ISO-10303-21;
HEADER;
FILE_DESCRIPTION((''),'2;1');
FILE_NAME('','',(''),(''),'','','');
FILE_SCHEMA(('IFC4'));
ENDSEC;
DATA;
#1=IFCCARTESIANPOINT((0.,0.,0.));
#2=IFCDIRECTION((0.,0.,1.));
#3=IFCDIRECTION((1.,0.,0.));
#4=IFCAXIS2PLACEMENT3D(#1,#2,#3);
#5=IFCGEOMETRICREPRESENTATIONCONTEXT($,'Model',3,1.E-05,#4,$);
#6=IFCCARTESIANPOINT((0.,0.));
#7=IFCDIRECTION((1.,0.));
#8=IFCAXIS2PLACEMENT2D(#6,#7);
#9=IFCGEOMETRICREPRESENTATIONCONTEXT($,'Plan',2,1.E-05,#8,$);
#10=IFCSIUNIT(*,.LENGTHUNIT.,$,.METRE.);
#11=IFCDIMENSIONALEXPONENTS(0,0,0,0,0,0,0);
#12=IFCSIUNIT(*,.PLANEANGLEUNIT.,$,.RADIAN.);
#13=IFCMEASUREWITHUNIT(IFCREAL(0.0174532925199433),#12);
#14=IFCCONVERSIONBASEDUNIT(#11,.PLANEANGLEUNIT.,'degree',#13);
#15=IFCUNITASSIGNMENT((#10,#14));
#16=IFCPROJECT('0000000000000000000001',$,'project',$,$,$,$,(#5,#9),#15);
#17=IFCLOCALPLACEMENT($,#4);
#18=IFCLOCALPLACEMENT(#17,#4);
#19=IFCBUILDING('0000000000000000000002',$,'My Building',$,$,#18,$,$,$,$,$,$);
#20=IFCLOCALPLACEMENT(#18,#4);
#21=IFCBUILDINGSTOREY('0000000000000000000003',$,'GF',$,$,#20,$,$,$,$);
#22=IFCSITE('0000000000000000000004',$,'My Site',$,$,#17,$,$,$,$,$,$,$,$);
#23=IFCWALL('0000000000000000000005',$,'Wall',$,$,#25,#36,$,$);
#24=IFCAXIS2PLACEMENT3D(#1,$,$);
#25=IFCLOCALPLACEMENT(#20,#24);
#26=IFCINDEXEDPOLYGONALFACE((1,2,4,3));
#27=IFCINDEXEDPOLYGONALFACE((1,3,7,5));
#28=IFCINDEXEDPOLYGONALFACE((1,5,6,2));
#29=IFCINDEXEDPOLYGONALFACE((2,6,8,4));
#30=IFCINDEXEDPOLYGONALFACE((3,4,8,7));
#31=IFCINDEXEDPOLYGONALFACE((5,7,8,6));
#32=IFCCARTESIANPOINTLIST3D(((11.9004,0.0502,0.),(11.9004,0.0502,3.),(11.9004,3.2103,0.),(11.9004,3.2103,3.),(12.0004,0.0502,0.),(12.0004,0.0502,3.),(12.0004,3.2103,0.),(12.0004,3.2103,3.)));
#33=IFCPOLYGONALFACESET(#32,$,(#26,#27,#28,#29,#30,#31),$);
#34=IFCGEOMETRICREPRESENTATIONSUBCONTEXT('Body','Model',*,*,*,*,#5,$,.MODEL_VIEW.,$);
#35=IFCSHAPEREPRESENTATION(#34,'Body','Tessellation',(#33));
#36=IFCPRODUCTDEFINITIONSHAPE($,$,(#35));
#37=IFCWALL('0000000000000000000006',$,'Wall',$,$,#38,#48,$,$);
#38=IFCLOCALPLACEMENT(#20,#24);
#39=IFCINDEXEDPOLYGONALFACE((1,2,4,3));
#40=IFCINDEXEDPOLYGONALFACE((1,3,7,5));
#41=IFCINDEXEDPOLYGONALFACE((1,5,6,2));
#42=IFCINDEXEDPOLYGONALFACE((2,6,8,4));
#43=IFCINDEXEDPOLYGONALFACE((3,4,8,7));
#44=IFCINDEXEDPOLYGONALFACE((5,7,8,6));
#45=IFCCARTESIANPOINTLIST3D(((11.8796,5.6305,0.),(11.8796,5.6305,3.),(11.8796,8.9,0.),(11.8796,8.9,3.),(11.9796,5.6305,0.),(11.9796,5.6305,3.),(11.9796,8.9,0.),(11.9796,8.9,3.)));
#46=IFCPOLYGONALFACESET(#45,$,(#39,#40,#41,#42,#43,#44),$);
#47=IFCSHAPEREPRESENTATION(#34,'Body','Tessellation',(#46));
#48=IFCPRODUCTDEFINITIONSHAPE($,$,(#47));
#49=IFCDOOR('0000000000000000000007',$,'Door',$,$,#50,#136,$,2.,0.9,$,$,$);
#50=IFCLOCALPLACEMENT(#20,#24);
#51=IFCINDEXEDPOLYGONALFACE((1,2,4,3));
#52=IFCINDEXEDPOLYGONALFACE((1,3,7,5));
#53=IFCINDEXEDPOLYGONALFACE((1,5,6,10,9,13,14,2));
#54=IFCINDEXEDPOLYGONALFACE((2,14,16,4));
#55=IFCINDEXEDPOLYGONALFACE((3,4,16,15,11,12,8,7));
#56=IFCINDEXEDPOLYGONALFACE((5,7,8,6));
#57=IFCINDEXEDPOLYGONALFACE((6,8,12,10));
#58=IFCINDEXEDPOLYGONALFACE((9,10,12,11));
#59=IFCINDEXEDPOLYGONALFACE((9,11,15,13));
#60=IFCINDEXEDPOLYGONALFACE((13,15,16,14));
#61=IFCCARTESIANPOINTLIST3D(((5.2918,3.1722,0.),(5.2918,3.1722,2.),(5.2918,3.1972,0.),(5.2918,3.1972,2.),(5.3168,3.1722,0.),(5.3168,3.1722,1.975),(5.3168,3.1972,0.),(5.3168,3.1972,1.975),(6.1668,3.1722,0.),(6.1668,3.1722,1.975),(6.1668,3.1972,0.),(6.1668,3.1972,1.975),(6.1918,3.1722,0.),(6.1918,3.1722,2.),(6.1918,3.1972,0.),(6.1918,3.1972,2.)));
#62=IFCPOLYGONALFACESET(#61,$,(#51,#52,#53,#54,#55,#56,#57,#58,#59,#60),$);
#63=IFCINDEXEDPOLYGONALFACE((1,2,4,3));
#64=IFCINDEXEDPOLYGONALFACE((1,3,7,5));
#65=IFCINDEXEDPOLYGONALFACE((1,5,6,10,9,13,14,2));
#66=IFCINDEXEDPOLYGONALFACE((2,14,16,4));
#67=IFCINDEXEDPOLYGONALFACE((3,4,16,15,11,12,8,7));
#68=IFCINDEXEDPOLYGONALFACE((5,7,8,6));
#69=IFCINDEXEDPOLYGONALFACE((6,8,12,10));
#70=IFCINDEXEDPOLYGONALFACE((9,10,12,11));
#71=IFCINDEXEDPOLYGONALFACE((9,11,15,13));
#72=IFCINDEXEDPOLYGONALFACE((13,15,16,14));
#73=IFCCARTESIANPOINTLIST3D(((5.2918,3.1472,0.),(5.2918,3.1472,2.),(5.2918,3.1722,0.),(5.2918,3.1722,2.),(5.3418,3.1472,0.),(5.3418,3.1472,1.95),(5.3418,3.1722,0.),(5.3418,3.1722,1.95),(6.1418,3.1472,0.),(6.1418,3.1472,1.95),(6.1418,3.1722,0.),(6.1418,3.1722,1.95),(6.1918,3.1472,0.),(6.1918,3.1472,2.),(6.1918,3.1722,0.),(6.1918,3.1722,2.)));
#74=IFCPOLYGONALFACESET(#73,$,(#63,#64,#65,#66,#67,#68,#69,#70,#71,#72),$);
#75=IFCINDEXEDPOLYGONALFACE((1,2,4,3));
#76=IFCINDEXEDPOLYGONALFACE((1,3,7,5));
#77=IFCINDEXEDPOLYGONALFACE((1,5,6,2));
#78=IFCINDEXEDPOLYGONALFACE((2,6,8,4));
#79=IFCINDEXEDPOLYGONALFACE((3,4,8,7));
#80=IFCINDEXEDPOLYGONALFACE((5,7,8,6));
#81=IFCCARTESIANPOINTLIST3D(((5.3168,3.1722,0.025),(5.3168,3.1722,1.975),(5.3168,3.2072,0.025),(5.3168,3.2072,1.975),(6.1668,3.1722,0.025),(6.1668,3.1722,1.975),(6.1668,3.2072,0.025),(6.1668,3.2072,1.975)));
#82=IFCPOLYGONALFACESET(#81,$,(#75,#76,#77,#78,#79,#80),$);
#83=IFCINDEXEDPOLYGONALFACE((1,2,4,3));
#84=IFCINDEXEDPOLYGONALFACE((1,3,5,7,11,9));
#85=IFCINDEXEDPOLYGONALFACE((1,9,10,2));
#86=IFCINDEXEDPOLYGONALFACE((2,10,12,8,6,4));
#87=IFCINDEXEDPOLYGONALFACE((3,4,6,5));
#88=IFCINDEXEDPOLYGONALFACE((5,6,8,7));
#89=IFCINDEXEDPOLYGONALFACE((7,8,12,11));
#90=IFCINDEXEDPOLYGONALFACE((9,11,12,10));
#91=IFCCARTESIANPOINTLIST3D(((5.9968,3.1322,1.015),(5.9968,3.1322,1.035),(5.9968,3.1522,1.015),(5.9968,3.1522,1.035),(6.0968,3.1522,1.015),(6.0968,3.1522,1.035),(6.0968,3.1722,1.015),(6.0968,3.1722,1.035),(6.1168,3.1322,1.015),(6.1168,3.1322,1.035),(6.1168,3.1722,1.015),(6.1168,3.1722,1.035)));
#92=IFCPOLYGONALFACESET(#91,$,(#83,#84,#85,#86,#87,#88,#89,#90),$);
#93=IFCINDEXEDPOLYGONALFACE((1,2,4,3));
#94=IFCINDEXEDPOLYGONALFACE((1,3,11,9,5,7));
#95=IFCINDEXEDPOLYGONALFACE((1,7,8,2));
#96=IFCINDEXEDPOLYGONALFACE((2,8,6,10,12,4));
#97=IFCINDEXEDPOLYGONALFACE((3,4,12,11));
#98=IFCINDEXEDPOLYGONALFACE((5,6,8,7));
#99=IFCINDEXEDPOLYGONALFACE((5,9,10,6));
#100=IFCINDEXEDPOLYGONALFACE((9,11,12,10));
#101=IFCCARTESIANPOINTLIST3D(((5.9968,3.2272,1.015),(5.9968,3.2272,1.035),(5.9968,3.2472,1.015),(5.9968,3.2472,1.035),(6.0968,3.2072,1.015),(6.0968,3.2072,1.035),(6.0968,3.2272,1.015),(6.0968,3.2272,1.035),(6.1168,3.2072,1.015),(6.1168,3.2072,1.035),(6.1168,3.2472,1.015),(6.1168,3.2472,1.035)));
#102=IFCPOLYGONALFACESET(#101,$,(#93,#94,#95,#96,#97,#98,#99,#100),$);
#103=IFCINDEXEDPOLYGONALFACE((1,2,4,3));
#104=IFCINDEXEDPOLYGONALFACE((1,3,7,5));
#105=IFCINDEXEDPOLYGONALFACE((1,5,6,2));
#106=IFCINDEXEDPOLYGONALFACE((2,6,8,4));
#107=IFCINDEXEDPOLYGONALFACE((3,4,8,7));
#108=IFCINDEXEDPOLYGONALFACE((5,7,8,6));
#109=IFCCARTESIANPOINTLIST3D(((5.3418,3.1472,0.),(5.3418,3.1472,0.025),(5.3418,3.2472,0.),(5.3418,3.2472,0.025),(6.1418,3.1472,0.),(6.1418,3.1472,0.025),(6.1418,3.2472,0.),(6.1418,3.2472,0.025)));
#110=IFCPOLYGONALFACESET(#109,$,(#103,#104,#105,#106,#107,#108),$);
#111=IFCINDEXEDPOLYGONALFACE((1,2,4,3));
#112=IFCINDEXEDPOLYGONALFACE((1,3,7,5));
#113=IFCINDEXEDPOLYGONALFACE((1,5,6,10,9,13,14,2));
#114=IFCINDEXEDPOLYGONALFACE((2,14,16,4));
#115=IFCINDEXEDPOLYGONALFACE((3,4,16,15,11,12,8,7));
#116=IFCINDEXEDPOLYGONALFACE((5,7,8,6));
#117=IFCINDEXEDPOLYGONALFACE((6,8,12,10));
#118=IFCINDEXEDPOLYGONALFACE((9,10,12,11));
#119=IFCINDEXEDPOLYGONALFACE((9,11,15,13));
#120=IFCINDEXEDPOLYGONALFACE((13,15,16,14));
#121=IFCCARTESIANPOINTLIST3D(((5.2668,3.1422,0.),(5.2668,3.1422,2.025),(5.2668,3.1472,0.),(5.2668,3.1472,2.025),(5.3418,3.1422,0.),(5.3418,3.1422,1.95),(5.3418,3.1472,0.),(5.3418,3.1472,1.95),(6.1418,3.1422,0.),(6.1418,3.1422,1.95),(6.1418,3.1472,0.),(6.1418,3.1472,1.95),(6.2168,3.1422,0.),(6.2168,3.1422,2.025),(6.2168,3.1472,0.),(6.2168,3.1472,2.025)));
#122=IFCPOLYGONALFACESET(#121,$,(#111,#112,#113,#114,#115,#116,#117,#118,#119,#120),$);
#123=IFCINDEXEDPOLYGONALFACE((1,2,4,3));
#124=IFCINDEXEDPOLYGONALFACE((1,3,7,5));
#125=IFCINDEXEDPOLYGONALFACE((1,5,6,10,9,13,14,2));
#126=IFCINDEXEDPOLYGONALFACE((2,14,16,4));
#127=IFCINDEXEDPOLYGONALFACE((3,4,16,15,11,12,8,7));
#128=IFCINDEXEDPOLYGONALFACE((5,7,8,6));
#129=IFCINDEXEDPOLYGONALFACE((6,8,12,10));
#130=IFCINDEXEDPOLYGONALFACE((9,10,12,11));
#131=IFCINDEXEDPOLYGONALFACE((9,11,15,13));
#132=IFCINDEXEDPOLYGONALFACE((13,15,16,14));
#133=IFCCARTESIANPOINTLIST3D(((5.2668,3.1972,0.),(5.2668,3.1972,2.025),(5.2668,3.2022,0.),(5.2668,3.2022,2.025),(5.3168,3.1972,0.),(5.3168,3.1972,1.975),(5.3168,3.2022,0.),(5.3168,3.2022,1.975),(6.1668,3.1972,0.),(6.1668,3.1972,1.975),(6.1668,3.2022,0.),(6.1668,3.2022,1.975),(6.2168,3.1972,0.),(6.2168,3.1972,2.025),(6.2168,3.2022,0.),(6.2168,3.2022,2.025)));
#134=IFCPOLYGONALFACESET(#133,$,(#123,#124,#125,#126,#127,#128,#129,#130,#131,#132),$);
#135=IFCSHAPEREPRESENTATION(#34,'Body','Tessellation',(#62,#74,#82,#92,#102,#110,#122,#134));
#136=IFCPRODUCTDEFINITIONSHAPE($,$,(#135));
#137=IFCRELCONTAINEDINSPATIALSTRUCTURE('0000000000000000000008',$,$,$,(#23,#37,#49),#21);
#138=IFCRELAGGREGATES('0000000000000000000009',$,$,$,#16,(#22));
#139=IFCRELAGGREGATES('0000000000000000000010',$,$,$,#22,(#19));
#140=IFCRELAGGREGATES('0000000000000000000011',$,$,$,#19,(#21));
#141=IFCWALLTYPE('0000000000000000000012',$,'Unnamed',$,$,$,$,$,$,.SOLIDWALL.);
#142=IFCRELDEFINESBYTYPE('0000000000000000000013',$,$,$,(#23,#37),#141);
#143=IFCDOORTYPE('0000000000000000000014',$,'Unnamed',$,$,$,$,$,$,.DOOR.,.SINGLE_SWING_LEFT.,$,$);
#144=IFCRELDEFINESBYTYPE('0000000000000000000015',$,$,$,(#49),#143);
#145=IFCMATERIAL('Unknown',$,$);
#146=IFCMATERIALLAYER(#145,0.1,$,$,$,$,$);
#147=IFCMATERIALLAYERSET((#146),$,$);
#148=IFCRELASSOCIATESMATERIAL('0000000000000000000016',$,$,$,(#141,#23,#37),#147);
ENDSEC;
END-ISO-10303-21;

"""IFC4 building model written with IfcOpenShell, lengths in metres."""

from ifc_helpers import new_model, entity, si_unit, converted_unit, frame, origin_with_axes, origin_2d_with_axis, place, context, subcontext, project, spatial, line, indexed_curve, outline, extrude, shape, source, transform, mapped, material, layer, layer_set, layer_usage, type_object, type_shapes, element, save


model = new_model("IFC4")

# Units and contexts
model_context = context("Model", 3, precision=1e-05, world=origin_with_axes())
plan_context = context("Plan", 2, precision=1e-05, world=origin_2d_with_axis())
body_context_1 = subcontext(model_context, "Body", "Model", "MODEL_VIEW")
body_context_2 = subcontext(plan_context, "Body", "Plan", "PLAN_VIEW")
ifc_project = project(units=[si_unit("LENGTHUNIT", "METRE"), converted_unit("PLANEANGLEUNIT", "degree", entity("IfcReal", 0.0174532925199433), si_unit("PLANEANGLEUNIT", "RADIAN"), dimensions=[0, 0, 0, 0, 0, 0, 0])], contexts=[model_context, plan_context])

# Site, building, storey
site_placement = place(None, origin_with_axes())
site = spatial("IfcSite", under=ifc_project, at=site_placement, Name="My Site")
building_placement = place(site_placement, origin_with_axes())
building = spatial("IfcBuilding", under=site, at=building_placement, Name="My Building")
storey_placement = place(building_placement, origin_with_axes())
storey = spatial("IfcBuildingStorey", under=building, at=storey_placement, Name="GF")

# Shared definitions
ifc_material = material(Name="Unknown")
ifc_layer = layer(ifc_material, 0.1)
ifc_layer_set = layer_set([ifc_layer])
wall_type = type_object("IfcWallType", Name="Unnamed", PredefinedType="SOLIDWALL", material=ifc_layer_set)
door_type = type_object("IfcDoorType", Name="Unnamed", OperationType="SINGLE_SWING_LEFT", PredefinedType="DOOR")
shared_shape_1 = source(origin_with_axes(), body_context_1, "Body", "SweptSolid", [
    extrude(outline(indexed_curve([(0.0, 0.0), (0.0, 2.0), (0.9, 2.0), (0.9, 0.0), (0.875, 0.0), (0.875, 1.975), (0.025, 1.975), (0.025, 0.0)], segments=[line(1, 2, 3, 4, 5, 6, 7, 8, 1)])), frame((0.0, 0.025, 0.0), z_axis=(0.0, -1.0, 0.0), x_axis=(1.0, 0.0, 0.0)), (0.0, 0.0, -1.0), 0.025),
    extrude(outline(indexed_curve([(0.0, 0.0), (0.0, 2.0), (0.9, 2.0), (0.9, 0.0), (0.85, 0.0), (0.85, 1.95), (0.05, 1.95), (0.05, 0.0)], segments=[line(1, 2, 3, 4, 5, 6, 7, 8, 1)])), frame((0.0, 0.0, 0.0), z_axis=(0.0, -1.0, 0.0), x_axis=(1.0, 0.0, 0.0)), (0.0, 0.0, -1.0), 0.025),
    extrude(outline(indexed_curve([(0.0, 0.0), (0.85, 0.0), (0.85, 0.035), (0.0, 0.035)], segments=[line(1, 2, 3, 4, 1)])), frame((0.025, 0.025, 0.025), z_axis=(0.0, 0.0, 1.0), x_axis=(1.0, 0.0, 0.0)), (0.0, 0.0, 1.0), 1.95),
    extrude(outline(indexed_curve([(0.0, 0.0), (0.0, -0.04), (-0.12, -0.04), (-0.12, -0.02), (-0.02, -0.02), (-0.02, 0.0)], segments=[line(1, 2, 3, 4, 5, 6, 1)])), frame((0.825, 0.025, 1.015), z_axis=(0.0, 0.0, 1.0), x_axis=(1.0, 0.0, 0.0)), (0.0, 0.0, 1.0), 0.02),
    extrude(outline(indexed_curve([(0.0, 0.0), (0.0, 0.04), (-0.12, 0.04), (-0.12, 0.02), (-0.02, 0.02), (-0.02, 0.0)], segments=[line(1, 2, 3, 4, 5, 6, 1)])), frame((0.825, 0.06, 1.015), z_axis=(0.0, 0.0, 1.0), x_axis=(1.0, 0.0, 0.0)), (0.0, 0.0, 1.0), 0.02),
    extrude(outline(indexed_curve([(0.0, 0.0), (0.8, 0.0), (0.8, 0.1), (0.0, 0.1)], segments=[line(1, 2, 3, 4, 1)])), frame((0.05, 0.0, 0.0), z_axis=(0.0, 0.0, 1.0), x_axis=(1.0, 0.0, 0.0)), (0.0, 0.0, 1.0), 0.025),
    extrude(outline(indexed_curve([(0.0, 0.0), (0.0, 2.025), (0.95, 2.025), (0.95, 0.0), (0.875, 0.0), (0.875, 1.95), (0.075, 1.95), (0.075, 0.0)], segments=[line(1, 2, 3, 4, 5, 6, 7, 8, 1)])), frame((-0.025, -0.005, 0.0), z_axis=(0.0, -1.0, 0.0), x_axis=(1.0, 0.0, 0.0)), (0.0, 0.0, -1.0), 0.005),
    extrude(outline(indexed_curve([(0.0, 0.0), (0.0, 2.025), (0.95, 2.025), (0.95, 0.0), (0.9, 0.0), (0.9, 1.975), (0.05, 1.975), (0.05, 0.0)], segments=[line(1, 2, 3, 4, 5, 6, 7, 8, 1)])), frame((-0.025, 0.05, 0.0), z_axis=(0.0, -1.0, 0.0), x_axis=(1.0, 0.0, 0.0)), (0.0, 0.0, -1.0), 0.005),
])
shared_shape_2 = source(origin_with_axes(), body_context_2, "Body", "Curve2D", [
    entity("IfcIndexedPolyCurve", entity("IfcCartesianPointList2D", [[0.0, 0.0], [0.0, 0.05], [0.025, 0.05], [0.025, 0.025], [0.05, 0.025], [0.05, 0.0]]), [entity("IfcLineIndex", [1, 2, 3, 4, 5, 6, 1])]),
    entity("IfcIndexedPolyCurve", entity("IfcCartesianPointList2D", [[0.9, 0.0], [0.9, 0.05], [0.875, 0.05], [0.875, 0.025], [0.85, 0.025], [0.85, 0.0]]), [entity("IfcLineIndex", [1, 2, 3, 4, 5, 6, 1])]),
    entity("IfcTrimmedCurve", entity("IfcEllipse", entity("IfcAxis2Placement2D", entity("IfcCartesianPoint", [0.06, 0.05]), entity("IfcDirection", [1.0, 0.0])), 0.815, 0.85), [entity("IfcCartesianPoint", [0.875, 0.05])], [entity("IfcCartesianPoint", [0.06, 0.9])], True, "CARTESIAN"),
    entity("IfcIndexedPolyCurve", entity("IfcCartesianPointList2D", [[0.025, 0.05], [0.06, 0.05], [0.06, 0.9], [0.025, 0.9]]), [entity("IfcLineIndex", [1, 2, 3, 4, 1])]),
])
type_shapes(door_type, [shared_shape_1, shared_shape_2])

# Walls
ifc_layer_usage_1 = layer_usage(ifc_layer_set, "AXIS2", "POSITIVE", 0.0)
wall_1_placement = place(storey_placement, frame((12.0004, 0.0502, 0.0), z_axis=(0.0, 0.0, 1.0), x_axis=(0.000013, 1.0, 0.0)))
element("IfcWall", 1, at=wall_1_placement, inside=storey, type_object=wall_type, material=ifc_layer_usage_1, Name="Wall", context=body_context_1, shape_type="SweptSolid", body=[
    extrude(outline(indexed_curve([(0.0, 0.0), (0.0, 0.1), (3.1602, 0.1), (3.1602, 0.0)], segments=[line(1, 2, 3, 4, 1)])), origin_with_axes(), (0.0, 0.0, 1.0), 3.0),
])
ifc_layer_usage_2 = layer_usage(ifc_layer_set, "AXIS2", "POSITIVE", 0.0)
wall_2_placement = place(storey_placement, frame((11.9796, 5.6305, 0.0), z_axis=(0.0, 0.0, 1.0), x_axis=(0.0, 1.0, 0.0)))
element("IfcWall", 2, at=wall_2_placement, inside=storey, type_object=wall_type, material=ifc_layer_usage_2, Name="Wall", context=body_context_1, shape_type="SweptSolid", body=[
    extrude(outline(indexed_curve([(0.0, 0.0), (0.0, 0.1), (3.2695, 0.1), (3.2695, 0.0)], segments=[line(1, 2, 3, 4, 1)])), origin_with_axes(), (0.0, 0.0, 1.0), 3.0),
])

# Door
placement_1 = place(storey_placement, frame((3.9897, 3.1472, 0.0), z_axis=(0.0, 0.0, 1.0), x_axis=(1.0, 0.0, 0.0)))
placement_2 = place(placement_1, frame((1.3021, 0.0, 0.0), z_axis=(0.0, 0.0, 1.0), x_axis=(1.0, 0.0, 0.0)))
for number, where, z_axis, x_axis, name in (
    (3, (0.0, 0.0, 0.0), (0.0, 0.0, 1.0), (1.0, 0.0, 0.0), "Door"),
):
    element("IfcDoor", number, at=place(placement_2, frame(where, z_axis=z_axis, x_axis=x_axis)), inside=storey, type_object=door_type, Name=name, OverallHeight=2.0, OverallWidth=0.9, shapes=[
        shape(body_context_1, "Body", "MappedRepresentation", [mapped(shared_shape_1, transform((0.0, 0.0, 0.0), x_axis=(1.0, 0.0, 0.0), y_axis=(0.0, 1.0, 0.0), z_axis=(0.0, 0.0, 1.0), scale=1.0))]),
        shape(body_context_2, "Body", "MappedRepresentation", [mapped(shared_shape_2, transform((0.0, 0.0, 0.0), x_axis=(1.0, 0.0, 0.0), y_axis=(0.0, 1.0, 0.0), z_axis=(0.0, 0.0, 1.0), scale=1.0))]),
    ])

save(model, "model.ifc")
